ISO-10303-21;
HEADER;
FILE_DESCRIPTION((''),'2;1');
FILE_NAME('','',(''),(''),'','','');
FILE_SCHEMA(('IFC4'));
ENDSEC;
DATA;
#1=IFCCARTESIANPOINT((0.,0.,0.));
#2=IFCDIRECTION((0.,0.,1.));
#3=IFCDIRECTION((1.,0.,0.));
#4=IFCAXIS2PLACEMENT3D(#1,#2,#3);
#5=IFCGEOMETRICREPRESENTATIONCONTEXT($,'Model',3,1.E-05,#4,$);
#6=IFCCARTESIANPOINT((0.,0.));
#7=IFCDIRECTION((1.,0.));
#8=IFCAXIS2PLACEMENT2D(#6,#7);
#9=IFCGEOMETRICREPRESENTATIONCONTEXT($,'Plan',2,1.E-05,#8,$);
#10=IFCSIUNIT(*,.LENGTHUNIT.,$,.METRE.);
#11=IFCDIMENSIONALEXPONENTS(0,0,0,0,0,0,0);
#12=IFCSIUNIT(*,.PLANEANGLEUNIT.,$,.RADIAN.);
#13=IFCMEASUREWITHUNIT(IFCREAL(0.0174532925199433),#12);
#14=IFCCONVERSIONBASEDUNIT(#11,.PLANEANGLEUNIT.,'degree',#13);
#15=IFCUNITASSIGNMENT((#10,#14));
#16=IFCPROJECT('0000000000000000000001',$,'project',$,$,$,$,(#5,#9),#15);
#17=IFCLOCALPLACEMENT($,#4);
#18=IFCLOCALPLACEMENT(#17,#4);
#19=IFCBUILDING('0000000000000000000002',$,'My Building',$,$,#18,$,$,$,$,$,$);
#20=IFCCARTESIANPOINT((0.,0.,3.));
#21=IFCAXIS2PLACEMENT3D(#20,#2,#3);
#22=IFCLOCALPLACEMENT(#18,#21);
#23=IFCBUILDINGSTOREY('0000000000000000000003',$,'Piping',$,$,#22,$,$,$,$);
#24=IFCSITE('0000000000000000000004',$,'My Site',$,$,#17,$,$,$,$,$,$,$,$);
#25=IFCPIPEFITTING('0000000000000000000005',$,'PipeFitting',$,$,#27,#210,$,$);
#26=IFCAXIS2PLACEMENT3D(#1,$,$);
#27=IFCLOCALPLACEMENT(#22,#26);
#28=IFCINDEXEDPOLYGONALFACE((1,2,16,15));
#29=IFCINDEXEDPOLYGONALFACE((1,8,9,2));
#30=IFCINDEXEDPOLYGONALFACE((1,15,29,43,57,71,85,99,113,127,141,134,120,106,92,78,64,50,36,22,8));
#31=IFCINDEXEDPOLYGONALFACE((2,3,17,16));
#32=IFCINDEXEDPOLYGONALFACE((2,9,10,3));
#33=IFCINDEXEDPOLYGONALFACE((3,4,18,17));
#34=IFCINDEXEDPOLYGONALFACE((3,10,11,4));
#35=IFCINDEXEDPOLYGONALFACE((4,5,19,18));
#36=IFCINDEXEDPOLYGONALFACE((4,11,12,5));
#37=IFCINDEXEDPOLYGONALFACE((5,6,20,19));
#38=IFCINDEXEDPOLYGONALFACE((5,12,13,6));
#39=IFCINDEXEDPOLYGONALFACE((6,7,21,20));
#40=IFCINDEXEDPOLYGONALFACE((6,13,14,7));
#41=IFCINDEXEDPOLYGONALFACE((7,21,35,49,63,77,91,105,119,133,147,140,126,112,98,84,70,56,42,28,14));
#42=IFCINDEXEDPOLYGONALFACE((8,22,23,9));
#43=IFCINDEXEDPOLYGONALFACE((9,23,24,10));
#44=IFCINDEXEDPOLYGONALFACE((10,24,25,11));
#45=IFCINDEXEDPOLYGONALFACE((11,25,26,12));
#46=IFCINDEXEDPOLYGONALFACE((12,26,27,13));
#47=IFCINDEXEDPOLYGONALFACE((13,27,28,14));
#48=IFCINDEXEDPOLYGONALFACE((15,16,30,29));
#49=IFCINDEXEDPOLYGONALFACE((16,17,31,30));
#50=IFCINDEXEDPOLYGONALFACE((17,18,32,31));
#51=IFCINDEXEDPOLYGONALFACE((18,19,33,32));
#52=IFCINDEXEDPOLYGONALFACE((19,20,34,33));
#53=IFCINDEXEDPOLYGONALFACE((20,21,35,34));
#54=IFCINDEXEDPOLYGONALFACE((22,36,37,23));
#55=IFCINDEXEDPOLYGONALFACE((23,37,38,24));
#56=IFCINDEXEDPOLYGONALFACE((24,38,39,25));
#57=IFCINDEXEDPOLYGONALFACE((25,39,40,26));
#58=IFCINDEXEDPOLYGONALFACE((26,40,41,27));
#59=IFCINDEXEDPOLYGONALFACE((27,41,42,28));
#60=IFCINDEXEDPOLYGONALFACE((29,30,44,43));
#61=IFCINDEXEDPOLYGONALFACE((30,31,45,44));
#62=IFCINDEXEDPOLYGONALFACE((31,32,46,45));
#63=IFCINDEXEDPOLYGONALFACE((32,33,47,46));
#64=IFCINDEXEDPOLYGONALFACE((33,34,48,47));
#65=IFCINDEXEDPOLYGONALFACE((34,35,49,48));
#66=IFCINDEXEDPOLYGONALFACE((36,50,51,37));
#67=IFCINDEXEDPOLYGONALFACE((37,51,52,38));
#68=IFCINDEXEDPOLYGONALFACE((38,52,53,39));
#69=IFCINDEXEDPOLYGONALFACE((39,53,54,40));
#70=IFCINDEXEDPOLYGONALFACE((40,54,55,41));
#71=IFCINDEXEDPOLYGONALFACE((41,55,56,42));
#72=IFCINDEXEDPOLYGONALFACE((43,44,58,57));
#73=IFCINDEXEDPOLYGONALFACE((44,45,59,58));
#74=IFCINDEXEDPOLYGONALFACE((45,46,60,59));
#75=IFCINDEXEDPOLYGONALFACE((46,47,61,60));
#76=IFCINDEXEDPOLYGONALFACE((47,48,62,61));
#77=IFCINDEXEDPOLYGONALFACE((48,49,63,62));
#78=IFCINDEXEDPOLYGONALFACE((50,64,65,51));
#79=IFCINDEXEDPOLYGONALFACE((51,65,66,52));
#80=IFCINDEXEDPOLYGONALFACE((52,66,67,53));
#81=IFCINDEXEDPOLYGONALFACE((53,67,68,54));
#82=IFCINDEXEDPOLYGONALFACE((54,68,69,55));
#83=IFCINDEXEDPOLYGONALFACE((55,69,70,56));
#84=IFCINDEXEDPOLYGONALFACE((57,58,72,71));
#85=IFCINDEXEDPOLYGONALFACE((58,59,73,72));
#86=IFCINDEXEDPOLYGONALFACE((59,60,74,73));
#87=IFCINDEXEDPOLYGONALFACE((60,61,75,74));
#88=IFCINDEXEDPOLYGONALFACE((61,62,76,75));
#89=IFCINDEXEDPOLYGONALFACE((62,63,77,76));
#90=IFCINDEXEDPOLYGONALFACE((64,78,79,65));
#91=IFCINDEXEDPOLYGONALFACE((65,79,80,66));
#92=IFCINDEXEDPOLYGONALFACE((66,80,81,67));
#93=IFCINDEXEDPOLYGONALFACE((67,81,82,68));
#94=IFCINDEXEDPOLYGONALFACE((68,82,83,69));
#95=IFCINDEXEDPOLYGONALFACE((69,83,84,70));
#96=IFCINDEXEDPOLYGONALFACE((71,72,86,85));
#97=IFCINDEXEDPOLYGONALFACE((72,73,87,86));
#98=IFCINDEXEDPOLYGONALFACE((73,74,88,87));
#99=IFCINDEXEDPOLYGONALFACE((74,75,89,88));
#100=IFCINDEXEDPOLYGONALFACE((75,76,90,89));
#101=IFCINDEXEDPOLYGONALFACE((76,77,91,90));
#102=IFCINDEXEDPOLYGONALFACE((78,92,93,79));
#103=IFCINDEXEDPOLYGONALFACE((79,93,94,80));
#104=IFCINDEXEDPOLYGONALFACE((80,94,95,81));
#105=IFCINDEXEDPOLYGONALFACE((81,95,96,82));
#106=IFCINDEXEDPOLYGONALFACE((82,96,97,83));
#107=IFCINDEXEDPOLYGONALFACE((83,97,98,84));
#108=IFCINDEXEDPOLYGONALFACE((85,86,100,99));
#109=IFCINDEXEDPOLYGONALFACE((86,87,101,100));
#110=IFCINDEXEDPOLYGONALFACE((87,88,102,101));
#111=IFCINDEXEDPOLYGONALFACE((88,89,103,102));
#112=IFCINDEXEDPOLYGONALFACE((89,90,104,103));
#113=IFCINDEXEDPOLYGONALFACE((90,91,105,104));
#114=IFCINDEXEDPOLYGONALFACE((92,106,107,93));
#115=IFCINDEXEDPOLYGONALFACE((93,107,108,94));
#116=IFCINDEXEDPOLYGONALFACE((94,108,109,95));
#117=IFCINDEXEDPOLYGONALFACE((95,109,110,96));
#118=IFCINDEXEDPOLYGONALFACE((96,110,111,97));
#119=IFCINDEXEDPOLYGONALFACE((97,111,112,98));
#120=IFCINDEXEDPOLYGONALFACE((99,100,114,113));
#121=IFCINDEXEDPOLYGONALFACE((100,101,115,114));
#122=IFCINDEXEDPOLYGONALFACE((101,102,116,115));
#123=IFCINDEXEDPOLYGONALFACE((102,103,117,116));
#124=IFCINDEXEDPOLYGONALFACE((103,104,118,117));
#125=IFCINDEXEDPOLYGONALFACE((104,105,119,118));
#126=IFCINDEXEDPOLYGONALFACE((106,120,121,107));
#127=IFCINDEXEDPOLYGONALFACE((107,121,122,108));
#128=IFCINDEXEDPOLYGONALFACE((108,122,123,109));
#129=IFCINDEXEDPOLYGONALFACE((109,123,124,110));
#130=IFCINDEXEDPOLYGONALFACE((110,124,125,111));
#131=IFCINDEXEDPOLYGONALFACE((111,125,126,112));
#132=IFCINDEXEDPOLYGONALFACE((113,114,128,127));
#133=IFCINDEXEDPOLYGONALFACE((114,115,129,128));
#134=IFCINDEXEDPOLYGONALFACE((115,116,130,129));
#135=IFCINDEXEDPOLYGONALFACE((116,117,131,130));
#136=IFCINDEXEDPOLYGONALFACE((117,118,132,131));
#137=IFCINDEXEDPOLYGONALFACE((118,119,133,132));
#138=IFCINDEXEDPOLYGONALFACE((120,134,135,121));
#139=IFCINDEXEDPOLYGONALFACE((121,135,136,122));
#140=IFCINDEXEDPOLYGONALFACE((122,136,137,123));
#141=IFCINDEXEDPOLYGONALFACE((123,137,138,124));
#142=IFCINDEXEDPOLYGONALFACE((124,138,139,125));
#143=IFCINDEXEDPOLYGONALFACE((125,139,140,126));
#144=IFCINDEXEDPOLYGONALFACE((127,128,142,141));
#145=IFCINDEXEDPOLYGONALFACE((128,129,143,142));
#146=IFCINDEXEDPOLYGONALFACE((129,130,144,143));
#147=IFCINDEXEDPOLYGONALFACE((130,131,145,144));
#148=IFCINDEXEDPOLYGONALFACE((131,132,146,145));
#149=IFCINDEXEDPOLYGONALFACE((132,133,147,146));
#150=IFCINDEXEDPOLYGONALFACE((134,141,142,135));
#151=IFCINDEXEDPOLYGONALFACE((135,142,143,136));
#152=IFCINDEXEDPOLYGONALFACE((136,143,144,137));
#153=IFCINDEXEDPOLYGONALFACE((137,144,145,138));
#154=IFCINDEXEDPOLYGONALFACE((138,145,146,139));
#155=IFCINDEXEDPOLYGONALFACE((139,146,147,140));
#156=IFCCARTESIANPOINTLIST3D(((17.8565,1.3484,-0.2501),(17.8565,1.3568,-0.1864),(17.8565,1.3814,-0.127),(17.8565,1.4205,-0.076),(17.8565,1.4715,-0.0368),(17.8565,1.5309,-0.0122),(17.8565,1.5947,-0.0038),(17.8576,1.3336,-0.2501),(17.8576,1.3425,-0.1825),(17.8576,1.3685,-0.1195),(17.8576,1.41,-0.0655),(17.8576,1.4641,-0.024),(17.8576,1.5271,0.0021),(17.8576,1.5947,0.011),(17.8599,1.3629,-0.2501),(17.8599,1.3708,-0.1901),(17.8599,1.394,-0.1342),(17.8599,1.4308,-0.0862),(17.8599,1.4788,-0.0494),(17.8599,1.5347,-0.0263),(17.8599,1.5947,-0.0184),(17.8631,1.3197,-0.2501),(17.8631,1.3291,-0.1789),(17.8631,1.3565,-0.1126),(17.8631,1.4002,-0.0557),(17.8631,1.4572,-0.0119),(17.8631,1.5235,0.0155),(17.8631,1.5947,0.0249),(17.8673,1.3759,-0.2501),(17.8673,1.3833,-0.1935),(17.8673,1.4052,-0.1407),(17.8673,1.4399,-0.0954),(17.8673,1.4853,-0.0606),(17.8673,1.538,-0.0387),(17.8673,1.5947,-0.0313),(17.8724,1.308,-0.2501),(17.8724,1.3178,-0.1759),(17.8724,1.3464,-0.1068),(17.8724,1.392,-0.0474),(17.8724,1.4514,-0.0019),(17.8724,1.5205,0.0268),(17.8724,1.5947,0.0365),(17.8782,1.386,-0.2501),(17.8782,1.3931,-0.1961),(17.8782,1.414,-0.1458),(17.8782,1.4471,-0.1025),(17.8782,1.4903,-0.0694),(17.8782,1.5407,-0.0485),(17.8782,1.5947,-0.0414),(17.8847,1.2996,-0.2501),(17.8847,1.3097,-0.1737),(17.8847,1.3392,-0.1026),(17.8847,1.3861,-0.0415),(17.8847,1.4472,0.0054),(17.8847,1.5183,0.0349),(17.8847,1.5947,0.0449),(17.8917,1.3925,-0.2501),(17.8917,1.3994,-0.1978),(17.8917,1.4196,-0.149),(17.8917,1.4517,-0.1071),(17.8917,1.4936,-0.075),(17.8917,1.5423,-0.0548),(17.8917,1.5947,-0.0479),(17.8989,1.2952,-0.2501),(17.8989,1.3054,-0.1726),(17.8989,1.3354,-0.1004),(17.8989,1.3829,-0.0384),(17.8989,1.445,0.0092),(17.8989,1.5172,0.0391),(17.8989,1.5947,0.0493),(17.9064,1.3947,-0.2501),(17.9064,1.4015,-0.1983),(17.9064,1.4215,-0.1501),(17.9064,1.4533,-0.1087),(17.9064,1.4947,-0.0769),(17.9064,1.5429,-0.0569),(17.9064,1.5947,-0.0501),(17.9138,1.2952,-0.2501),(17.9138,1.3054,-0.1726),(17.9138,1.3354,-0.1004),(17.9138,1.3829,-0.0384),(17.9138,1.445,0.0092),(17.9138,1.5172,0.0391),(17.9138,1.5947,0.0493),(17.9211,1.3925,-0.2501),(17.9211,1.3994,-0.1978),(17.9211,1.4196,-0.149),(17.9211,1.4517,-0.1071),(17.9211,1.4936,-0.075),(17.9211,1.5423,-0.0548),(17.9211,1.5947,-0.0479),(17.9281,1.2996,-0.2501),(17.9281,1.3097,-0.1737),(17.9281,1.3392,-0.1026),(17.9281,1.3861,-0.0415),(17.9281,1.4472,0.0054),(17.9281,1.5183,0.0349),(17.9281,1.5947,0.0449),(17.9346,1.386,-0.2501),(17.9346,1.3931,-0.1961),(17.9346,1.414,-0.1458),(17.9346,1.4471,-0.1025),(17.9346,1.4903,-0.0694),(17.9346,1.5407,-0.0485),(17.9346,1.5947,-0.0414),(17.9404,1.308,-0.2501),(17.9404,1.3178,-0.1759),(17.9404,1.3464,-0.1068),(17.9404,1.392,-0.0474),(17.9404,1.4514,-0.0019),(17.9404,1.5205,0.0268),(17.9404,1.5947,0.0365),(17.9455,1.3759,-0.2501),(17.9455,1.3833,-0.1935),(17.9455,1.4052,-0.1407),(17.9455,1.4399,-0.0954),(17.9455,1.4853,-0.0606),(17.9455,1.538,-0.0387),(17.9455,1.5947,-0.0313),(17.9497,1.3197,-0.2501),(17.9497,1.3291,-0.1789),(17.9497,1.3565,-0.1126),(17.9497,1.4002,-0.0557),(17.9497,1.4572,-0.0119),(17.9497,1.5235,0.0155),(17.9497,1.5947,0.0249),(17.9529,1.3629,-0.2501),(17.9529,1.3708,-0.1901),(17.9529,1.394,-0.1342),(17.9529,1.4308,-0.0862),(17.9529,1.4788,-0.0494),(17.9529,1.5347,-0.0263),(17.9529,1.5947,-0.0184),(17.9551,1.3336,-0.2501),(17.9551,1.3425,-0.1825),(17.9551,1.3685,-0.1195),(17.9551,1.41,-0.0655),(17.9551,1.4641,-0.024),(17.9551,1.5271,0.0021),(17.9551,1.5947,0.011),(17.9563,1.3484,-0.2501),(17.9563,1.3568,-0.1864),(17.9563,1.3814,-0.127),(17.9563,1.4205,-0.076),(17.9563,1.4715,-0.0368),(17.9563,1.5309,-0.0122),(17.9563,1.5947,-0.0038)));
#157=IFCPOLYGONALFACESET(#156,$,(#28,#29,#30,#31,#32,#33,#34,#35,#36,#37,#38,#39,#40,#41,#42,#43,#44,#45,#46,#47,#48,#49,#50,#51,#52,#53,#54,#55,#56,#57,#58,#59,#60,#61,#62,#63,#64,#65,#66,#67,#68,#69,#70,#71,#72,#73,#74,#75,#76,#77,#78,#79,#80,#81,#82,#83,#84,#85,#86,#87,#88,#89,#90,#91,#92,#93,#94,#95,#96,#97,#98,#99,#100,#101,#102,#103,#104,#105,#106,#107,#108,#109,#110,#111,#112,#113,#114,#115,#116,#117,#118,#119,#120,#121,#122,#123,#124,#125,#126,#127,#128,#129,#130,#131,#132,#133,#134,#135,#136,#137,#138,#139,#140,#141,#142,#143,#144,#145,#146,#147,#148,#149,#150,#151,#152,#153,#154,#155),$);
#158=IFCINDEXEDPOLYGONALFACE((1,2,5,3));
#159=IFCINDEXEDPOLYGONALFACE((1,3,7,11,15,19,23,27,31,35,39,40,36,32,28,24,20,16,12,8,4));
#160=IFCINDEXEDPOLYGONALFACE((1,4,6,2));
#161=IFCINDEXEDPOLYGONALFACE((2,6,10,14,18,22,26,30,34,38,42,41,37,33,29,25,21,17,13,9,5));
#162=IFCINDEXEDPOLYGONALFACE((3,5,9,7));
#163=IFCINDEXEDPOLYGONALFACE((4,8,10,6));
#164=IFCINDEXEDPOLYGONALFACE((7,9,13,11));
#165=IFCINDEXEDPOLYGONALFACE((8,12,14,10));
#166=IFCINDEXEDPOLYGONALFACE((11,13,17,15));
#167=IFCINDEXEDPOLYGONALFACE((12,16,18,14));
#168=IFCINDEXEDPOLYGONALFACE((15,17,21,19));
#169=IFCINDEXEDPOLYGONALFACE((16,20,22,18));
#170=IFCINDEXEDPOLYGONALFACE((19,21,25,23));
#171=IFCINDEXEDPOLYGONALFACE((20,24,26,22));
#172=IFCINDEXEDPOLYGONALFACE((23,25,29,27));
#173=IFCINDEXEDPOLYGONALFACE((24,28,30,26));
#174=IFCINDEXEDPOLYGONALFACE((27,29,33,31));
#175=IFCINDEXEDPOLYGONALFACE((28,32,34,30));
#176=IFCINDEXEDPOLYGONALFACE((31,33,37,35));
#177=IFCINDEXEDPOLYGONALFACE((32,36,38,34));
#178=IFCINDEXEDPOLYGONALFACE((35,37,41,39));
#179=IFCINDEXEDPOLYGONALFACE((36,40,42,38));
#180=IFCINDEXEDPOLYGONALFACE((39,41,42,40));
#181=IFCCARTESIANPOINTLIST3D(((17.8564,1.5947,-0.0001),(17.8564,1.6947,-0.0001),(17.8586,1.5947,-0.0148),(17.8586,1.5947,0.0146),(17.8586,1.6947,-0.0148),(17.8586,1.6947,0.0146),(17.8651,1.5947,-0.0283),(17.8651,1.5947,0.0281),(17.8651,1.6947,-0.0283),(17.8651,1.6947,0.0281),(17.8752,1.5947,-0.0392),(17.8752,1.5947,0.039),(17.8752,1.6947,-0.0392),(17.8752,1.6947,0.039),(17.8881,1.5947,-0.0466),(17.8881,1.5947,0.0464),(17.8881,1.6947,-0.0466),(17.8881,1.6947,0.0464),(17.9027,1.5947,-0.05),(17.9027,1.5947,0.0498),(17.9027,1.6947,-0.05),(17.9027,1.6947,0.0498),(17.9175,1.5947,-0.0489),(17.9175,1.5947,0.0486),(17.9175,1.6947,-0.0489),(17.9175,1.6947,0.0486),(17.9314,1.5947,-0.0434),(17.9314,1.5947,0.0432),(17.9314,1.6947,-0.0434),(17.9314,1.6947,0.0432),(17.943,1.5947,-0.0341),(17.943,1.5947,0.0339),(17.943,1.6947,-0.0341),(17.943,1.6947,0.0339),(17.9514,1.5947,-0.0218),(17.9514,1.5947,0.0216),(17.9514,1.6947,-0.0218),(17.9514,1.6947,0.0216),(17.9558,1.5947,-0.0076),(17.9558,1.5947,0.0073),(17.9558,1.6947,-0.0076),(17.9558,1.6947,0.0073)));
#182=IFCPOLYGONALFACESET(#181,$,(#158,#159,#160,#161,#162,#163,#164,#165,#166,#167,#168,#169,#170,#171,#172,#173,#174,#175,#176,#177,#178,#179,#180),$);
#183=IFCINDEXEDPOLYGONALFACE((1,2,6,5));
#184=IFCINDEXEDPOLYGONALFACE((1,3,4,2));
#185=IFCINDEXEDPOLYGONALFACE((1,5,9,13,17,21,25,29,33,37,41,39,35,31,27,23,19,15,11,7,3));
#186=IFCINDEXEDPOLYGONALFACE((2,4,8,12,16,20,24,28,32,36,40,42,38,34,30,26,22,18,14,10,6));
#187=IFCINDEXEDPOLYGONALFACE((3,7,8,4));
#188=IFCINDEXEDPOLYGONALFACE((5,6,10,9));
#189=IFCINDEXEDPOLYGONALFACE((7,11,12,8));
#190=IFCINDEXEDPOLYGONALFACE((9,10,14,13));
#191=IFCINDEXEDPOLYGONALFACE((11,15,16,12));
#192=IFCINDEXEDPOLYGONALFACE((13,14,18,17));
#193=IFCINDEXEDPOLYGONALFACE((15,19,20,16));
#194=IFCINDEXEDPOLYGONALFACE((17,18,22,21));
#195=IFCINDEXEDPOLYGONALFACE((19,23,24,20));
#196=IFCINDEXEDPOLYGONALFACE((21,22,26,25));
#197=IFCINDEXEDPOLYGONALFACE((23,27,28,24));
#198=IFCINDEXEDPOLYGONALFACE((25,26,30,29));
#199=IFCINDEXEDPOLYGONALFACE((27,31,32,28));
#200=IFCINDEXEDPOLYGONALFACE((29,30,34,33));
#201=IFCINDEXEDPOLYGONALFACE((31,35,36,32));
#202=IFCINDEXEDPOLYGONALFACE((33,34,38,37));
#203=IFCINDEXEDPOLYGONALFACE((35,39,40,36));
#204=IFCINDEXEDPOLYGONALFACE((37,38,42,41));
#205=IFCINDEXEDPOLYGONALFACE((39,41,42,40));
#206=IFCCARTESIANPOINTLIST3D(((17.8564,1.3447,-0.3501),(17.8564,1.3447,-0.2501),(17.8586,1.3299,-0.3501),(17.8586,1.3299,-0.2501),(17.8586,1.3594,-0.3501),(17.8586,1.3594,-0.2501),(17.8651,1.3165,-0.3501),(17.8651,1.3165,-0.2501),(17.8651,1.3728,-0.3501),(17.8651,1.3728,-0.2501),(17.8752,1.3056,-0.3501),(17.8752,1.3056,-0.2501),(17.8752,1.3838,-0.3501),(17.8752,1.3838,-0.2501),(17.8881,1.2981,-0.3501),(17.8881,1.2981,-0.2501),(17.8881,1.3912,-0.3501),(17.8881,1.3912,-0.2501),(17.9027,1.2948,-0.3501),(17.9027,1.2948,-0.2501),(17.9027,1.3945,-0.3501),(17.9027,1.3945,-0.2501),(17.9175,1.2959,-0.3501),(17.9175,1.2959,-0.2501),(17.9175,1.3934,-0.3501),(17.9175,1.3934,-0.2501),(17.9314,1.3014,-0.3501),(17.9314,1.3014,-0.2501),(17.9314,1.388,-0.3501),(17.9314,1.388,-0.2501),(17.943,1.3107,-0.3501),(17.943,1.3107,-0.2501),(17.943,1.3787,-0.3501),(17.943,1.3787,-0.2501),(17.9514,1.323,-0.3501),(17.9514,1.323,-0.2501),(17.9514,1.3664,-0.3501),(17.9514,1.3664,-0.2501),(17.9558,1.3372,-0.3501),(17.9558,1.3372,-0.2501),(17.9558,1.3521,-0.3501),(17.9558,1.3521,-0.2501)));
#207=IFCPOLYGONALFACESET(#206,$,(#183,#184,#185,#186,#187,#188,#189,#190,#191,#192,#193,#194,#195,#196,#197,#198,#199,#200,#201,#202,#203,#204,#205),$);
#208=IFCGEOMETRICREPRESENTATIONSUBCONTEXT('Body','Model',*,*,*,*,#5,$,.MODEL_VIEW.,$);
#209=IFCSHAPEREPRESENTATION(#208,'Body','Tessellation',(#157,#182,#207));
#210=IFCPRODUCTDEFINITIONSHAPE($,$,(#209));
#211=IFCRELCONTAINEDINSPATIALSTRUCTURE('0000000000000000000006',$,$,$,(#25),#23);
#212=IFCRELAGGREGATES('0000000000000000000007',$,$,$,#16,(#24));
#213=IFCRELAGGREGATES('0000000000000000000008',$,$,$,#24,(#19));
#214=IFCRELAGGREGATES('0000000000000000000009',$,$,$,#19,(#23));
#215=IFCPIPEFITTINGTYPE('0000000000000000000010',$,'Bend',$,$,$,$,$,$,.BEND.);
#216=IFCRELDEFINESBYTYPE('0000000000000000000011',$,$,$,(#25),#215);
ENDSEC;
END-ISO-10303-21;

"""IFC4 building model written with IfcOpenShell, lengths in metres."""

from ifc_helpers import new_model, entity, si_unit, converted_unit, frame, origin_with_axes, origin_2d_with_axis, place, context, subcontext, project, spatial, circle, extrude, source, transform, mapped, type_object, type_shapes, element, save


model = new_model("IFC4")

# Units and contexts
model_context = context("Model", 3, precision=1e-05, world=origin_with_axes())
plan_context = context("Plan", 2, precision=1e-05, world=origin_2d_with_axis())
body_context = subcontext(model_context, "Body", "Model", "MODEL_VIEW")
ifc_project = project(units=[si_unit("LENGTHUNIT", "METRE"), converted_unit("PLANEANGLEUNIT", "degree", entity("IfcReal", 0.0174532925199433), si_unit("PLANEANGLEUNIT", "RADIAN"), dimensions=[0, 0, 0, 0, 0, 0, 0])], contexts=[model_context, plan_context])

# Site, building, storey
site_placement = place(None, origin_with_axes())
site = spatial("IfcSite", under=ifc_project, at=site_placement, Name="My Site")
building_placement = place(site_placement, origin_with_axes())
building = spatial("IfcBuilding", under=site, at=building_placement, Name="My Building")
storey_placement = place(building_placement, frame((0.0, 0.0, 3.0), z_axis=(0.0, 0.0, 1.0), x_axis=(1.0, 0.0, 0.0)))
storey = spatial("IfcBuildingStorey", under=building, at=storey_placement, Name="Piping")

# Pipe fitting
pipe_fitting_type = type_object("IfcPipeFittingType", Name="Bend", PredefinedType="BEND")
shared_shape = source(origin_with_axes(), body_context, "Body", "SolidModel", [
    entity("IfcSweptDiskSolid", entity("IfcIndexedPolyCurve", entity("IfcCartesianPointList3D", [[0.0, 0.0, -0.1], [0.0, -0.0732, -0.2768], [0.0, -0.25, -0.35]]), [entity("IfcArcIndex", [1, 2, 3])]), 0.05),
    extrude(circle(Radius=0.05), origin_with_axes(), (0.0, 0.0, -1.0), 0.1),
    extrude(circle(Radius=0.05), frame((0.0, -0.25, -0.35), z_axis=(0.0, -1.0, 0.0), x_axis=(1.0, 0.0, 0.0)), (0.0, 0.0, 1.0), 0.1),
])
type_shapes(pipe_fitting_type, [shared_shape])
for number, where, z_axis, x_axis, name in (
    (1, (17.9064, 1.6947, -0.0001), (0.0, 1.0, 0.0), (-1.0, 0.0, 0.0), "PipeFitting"),
):
    element("IfcPipeFitting", number, at=place(storey_placement, frame(where, z_axis=z_axis, x_axis=x_axis)), inside=storey, type_object=pipe_fitting_type, Name=name, context=body_context, shape_type="MappedRepresentation", body=[
        mapped(shared_shape, transform((0.0, 0.0, 0.0), x_axis=(1.0, 0.0, 0.0), y_axis=(0.0, 1.0, 0.0), z_axis=(0.0, 0.0, 1.0), scale=1.0)),
    ])

save(model, "model.ifc")
